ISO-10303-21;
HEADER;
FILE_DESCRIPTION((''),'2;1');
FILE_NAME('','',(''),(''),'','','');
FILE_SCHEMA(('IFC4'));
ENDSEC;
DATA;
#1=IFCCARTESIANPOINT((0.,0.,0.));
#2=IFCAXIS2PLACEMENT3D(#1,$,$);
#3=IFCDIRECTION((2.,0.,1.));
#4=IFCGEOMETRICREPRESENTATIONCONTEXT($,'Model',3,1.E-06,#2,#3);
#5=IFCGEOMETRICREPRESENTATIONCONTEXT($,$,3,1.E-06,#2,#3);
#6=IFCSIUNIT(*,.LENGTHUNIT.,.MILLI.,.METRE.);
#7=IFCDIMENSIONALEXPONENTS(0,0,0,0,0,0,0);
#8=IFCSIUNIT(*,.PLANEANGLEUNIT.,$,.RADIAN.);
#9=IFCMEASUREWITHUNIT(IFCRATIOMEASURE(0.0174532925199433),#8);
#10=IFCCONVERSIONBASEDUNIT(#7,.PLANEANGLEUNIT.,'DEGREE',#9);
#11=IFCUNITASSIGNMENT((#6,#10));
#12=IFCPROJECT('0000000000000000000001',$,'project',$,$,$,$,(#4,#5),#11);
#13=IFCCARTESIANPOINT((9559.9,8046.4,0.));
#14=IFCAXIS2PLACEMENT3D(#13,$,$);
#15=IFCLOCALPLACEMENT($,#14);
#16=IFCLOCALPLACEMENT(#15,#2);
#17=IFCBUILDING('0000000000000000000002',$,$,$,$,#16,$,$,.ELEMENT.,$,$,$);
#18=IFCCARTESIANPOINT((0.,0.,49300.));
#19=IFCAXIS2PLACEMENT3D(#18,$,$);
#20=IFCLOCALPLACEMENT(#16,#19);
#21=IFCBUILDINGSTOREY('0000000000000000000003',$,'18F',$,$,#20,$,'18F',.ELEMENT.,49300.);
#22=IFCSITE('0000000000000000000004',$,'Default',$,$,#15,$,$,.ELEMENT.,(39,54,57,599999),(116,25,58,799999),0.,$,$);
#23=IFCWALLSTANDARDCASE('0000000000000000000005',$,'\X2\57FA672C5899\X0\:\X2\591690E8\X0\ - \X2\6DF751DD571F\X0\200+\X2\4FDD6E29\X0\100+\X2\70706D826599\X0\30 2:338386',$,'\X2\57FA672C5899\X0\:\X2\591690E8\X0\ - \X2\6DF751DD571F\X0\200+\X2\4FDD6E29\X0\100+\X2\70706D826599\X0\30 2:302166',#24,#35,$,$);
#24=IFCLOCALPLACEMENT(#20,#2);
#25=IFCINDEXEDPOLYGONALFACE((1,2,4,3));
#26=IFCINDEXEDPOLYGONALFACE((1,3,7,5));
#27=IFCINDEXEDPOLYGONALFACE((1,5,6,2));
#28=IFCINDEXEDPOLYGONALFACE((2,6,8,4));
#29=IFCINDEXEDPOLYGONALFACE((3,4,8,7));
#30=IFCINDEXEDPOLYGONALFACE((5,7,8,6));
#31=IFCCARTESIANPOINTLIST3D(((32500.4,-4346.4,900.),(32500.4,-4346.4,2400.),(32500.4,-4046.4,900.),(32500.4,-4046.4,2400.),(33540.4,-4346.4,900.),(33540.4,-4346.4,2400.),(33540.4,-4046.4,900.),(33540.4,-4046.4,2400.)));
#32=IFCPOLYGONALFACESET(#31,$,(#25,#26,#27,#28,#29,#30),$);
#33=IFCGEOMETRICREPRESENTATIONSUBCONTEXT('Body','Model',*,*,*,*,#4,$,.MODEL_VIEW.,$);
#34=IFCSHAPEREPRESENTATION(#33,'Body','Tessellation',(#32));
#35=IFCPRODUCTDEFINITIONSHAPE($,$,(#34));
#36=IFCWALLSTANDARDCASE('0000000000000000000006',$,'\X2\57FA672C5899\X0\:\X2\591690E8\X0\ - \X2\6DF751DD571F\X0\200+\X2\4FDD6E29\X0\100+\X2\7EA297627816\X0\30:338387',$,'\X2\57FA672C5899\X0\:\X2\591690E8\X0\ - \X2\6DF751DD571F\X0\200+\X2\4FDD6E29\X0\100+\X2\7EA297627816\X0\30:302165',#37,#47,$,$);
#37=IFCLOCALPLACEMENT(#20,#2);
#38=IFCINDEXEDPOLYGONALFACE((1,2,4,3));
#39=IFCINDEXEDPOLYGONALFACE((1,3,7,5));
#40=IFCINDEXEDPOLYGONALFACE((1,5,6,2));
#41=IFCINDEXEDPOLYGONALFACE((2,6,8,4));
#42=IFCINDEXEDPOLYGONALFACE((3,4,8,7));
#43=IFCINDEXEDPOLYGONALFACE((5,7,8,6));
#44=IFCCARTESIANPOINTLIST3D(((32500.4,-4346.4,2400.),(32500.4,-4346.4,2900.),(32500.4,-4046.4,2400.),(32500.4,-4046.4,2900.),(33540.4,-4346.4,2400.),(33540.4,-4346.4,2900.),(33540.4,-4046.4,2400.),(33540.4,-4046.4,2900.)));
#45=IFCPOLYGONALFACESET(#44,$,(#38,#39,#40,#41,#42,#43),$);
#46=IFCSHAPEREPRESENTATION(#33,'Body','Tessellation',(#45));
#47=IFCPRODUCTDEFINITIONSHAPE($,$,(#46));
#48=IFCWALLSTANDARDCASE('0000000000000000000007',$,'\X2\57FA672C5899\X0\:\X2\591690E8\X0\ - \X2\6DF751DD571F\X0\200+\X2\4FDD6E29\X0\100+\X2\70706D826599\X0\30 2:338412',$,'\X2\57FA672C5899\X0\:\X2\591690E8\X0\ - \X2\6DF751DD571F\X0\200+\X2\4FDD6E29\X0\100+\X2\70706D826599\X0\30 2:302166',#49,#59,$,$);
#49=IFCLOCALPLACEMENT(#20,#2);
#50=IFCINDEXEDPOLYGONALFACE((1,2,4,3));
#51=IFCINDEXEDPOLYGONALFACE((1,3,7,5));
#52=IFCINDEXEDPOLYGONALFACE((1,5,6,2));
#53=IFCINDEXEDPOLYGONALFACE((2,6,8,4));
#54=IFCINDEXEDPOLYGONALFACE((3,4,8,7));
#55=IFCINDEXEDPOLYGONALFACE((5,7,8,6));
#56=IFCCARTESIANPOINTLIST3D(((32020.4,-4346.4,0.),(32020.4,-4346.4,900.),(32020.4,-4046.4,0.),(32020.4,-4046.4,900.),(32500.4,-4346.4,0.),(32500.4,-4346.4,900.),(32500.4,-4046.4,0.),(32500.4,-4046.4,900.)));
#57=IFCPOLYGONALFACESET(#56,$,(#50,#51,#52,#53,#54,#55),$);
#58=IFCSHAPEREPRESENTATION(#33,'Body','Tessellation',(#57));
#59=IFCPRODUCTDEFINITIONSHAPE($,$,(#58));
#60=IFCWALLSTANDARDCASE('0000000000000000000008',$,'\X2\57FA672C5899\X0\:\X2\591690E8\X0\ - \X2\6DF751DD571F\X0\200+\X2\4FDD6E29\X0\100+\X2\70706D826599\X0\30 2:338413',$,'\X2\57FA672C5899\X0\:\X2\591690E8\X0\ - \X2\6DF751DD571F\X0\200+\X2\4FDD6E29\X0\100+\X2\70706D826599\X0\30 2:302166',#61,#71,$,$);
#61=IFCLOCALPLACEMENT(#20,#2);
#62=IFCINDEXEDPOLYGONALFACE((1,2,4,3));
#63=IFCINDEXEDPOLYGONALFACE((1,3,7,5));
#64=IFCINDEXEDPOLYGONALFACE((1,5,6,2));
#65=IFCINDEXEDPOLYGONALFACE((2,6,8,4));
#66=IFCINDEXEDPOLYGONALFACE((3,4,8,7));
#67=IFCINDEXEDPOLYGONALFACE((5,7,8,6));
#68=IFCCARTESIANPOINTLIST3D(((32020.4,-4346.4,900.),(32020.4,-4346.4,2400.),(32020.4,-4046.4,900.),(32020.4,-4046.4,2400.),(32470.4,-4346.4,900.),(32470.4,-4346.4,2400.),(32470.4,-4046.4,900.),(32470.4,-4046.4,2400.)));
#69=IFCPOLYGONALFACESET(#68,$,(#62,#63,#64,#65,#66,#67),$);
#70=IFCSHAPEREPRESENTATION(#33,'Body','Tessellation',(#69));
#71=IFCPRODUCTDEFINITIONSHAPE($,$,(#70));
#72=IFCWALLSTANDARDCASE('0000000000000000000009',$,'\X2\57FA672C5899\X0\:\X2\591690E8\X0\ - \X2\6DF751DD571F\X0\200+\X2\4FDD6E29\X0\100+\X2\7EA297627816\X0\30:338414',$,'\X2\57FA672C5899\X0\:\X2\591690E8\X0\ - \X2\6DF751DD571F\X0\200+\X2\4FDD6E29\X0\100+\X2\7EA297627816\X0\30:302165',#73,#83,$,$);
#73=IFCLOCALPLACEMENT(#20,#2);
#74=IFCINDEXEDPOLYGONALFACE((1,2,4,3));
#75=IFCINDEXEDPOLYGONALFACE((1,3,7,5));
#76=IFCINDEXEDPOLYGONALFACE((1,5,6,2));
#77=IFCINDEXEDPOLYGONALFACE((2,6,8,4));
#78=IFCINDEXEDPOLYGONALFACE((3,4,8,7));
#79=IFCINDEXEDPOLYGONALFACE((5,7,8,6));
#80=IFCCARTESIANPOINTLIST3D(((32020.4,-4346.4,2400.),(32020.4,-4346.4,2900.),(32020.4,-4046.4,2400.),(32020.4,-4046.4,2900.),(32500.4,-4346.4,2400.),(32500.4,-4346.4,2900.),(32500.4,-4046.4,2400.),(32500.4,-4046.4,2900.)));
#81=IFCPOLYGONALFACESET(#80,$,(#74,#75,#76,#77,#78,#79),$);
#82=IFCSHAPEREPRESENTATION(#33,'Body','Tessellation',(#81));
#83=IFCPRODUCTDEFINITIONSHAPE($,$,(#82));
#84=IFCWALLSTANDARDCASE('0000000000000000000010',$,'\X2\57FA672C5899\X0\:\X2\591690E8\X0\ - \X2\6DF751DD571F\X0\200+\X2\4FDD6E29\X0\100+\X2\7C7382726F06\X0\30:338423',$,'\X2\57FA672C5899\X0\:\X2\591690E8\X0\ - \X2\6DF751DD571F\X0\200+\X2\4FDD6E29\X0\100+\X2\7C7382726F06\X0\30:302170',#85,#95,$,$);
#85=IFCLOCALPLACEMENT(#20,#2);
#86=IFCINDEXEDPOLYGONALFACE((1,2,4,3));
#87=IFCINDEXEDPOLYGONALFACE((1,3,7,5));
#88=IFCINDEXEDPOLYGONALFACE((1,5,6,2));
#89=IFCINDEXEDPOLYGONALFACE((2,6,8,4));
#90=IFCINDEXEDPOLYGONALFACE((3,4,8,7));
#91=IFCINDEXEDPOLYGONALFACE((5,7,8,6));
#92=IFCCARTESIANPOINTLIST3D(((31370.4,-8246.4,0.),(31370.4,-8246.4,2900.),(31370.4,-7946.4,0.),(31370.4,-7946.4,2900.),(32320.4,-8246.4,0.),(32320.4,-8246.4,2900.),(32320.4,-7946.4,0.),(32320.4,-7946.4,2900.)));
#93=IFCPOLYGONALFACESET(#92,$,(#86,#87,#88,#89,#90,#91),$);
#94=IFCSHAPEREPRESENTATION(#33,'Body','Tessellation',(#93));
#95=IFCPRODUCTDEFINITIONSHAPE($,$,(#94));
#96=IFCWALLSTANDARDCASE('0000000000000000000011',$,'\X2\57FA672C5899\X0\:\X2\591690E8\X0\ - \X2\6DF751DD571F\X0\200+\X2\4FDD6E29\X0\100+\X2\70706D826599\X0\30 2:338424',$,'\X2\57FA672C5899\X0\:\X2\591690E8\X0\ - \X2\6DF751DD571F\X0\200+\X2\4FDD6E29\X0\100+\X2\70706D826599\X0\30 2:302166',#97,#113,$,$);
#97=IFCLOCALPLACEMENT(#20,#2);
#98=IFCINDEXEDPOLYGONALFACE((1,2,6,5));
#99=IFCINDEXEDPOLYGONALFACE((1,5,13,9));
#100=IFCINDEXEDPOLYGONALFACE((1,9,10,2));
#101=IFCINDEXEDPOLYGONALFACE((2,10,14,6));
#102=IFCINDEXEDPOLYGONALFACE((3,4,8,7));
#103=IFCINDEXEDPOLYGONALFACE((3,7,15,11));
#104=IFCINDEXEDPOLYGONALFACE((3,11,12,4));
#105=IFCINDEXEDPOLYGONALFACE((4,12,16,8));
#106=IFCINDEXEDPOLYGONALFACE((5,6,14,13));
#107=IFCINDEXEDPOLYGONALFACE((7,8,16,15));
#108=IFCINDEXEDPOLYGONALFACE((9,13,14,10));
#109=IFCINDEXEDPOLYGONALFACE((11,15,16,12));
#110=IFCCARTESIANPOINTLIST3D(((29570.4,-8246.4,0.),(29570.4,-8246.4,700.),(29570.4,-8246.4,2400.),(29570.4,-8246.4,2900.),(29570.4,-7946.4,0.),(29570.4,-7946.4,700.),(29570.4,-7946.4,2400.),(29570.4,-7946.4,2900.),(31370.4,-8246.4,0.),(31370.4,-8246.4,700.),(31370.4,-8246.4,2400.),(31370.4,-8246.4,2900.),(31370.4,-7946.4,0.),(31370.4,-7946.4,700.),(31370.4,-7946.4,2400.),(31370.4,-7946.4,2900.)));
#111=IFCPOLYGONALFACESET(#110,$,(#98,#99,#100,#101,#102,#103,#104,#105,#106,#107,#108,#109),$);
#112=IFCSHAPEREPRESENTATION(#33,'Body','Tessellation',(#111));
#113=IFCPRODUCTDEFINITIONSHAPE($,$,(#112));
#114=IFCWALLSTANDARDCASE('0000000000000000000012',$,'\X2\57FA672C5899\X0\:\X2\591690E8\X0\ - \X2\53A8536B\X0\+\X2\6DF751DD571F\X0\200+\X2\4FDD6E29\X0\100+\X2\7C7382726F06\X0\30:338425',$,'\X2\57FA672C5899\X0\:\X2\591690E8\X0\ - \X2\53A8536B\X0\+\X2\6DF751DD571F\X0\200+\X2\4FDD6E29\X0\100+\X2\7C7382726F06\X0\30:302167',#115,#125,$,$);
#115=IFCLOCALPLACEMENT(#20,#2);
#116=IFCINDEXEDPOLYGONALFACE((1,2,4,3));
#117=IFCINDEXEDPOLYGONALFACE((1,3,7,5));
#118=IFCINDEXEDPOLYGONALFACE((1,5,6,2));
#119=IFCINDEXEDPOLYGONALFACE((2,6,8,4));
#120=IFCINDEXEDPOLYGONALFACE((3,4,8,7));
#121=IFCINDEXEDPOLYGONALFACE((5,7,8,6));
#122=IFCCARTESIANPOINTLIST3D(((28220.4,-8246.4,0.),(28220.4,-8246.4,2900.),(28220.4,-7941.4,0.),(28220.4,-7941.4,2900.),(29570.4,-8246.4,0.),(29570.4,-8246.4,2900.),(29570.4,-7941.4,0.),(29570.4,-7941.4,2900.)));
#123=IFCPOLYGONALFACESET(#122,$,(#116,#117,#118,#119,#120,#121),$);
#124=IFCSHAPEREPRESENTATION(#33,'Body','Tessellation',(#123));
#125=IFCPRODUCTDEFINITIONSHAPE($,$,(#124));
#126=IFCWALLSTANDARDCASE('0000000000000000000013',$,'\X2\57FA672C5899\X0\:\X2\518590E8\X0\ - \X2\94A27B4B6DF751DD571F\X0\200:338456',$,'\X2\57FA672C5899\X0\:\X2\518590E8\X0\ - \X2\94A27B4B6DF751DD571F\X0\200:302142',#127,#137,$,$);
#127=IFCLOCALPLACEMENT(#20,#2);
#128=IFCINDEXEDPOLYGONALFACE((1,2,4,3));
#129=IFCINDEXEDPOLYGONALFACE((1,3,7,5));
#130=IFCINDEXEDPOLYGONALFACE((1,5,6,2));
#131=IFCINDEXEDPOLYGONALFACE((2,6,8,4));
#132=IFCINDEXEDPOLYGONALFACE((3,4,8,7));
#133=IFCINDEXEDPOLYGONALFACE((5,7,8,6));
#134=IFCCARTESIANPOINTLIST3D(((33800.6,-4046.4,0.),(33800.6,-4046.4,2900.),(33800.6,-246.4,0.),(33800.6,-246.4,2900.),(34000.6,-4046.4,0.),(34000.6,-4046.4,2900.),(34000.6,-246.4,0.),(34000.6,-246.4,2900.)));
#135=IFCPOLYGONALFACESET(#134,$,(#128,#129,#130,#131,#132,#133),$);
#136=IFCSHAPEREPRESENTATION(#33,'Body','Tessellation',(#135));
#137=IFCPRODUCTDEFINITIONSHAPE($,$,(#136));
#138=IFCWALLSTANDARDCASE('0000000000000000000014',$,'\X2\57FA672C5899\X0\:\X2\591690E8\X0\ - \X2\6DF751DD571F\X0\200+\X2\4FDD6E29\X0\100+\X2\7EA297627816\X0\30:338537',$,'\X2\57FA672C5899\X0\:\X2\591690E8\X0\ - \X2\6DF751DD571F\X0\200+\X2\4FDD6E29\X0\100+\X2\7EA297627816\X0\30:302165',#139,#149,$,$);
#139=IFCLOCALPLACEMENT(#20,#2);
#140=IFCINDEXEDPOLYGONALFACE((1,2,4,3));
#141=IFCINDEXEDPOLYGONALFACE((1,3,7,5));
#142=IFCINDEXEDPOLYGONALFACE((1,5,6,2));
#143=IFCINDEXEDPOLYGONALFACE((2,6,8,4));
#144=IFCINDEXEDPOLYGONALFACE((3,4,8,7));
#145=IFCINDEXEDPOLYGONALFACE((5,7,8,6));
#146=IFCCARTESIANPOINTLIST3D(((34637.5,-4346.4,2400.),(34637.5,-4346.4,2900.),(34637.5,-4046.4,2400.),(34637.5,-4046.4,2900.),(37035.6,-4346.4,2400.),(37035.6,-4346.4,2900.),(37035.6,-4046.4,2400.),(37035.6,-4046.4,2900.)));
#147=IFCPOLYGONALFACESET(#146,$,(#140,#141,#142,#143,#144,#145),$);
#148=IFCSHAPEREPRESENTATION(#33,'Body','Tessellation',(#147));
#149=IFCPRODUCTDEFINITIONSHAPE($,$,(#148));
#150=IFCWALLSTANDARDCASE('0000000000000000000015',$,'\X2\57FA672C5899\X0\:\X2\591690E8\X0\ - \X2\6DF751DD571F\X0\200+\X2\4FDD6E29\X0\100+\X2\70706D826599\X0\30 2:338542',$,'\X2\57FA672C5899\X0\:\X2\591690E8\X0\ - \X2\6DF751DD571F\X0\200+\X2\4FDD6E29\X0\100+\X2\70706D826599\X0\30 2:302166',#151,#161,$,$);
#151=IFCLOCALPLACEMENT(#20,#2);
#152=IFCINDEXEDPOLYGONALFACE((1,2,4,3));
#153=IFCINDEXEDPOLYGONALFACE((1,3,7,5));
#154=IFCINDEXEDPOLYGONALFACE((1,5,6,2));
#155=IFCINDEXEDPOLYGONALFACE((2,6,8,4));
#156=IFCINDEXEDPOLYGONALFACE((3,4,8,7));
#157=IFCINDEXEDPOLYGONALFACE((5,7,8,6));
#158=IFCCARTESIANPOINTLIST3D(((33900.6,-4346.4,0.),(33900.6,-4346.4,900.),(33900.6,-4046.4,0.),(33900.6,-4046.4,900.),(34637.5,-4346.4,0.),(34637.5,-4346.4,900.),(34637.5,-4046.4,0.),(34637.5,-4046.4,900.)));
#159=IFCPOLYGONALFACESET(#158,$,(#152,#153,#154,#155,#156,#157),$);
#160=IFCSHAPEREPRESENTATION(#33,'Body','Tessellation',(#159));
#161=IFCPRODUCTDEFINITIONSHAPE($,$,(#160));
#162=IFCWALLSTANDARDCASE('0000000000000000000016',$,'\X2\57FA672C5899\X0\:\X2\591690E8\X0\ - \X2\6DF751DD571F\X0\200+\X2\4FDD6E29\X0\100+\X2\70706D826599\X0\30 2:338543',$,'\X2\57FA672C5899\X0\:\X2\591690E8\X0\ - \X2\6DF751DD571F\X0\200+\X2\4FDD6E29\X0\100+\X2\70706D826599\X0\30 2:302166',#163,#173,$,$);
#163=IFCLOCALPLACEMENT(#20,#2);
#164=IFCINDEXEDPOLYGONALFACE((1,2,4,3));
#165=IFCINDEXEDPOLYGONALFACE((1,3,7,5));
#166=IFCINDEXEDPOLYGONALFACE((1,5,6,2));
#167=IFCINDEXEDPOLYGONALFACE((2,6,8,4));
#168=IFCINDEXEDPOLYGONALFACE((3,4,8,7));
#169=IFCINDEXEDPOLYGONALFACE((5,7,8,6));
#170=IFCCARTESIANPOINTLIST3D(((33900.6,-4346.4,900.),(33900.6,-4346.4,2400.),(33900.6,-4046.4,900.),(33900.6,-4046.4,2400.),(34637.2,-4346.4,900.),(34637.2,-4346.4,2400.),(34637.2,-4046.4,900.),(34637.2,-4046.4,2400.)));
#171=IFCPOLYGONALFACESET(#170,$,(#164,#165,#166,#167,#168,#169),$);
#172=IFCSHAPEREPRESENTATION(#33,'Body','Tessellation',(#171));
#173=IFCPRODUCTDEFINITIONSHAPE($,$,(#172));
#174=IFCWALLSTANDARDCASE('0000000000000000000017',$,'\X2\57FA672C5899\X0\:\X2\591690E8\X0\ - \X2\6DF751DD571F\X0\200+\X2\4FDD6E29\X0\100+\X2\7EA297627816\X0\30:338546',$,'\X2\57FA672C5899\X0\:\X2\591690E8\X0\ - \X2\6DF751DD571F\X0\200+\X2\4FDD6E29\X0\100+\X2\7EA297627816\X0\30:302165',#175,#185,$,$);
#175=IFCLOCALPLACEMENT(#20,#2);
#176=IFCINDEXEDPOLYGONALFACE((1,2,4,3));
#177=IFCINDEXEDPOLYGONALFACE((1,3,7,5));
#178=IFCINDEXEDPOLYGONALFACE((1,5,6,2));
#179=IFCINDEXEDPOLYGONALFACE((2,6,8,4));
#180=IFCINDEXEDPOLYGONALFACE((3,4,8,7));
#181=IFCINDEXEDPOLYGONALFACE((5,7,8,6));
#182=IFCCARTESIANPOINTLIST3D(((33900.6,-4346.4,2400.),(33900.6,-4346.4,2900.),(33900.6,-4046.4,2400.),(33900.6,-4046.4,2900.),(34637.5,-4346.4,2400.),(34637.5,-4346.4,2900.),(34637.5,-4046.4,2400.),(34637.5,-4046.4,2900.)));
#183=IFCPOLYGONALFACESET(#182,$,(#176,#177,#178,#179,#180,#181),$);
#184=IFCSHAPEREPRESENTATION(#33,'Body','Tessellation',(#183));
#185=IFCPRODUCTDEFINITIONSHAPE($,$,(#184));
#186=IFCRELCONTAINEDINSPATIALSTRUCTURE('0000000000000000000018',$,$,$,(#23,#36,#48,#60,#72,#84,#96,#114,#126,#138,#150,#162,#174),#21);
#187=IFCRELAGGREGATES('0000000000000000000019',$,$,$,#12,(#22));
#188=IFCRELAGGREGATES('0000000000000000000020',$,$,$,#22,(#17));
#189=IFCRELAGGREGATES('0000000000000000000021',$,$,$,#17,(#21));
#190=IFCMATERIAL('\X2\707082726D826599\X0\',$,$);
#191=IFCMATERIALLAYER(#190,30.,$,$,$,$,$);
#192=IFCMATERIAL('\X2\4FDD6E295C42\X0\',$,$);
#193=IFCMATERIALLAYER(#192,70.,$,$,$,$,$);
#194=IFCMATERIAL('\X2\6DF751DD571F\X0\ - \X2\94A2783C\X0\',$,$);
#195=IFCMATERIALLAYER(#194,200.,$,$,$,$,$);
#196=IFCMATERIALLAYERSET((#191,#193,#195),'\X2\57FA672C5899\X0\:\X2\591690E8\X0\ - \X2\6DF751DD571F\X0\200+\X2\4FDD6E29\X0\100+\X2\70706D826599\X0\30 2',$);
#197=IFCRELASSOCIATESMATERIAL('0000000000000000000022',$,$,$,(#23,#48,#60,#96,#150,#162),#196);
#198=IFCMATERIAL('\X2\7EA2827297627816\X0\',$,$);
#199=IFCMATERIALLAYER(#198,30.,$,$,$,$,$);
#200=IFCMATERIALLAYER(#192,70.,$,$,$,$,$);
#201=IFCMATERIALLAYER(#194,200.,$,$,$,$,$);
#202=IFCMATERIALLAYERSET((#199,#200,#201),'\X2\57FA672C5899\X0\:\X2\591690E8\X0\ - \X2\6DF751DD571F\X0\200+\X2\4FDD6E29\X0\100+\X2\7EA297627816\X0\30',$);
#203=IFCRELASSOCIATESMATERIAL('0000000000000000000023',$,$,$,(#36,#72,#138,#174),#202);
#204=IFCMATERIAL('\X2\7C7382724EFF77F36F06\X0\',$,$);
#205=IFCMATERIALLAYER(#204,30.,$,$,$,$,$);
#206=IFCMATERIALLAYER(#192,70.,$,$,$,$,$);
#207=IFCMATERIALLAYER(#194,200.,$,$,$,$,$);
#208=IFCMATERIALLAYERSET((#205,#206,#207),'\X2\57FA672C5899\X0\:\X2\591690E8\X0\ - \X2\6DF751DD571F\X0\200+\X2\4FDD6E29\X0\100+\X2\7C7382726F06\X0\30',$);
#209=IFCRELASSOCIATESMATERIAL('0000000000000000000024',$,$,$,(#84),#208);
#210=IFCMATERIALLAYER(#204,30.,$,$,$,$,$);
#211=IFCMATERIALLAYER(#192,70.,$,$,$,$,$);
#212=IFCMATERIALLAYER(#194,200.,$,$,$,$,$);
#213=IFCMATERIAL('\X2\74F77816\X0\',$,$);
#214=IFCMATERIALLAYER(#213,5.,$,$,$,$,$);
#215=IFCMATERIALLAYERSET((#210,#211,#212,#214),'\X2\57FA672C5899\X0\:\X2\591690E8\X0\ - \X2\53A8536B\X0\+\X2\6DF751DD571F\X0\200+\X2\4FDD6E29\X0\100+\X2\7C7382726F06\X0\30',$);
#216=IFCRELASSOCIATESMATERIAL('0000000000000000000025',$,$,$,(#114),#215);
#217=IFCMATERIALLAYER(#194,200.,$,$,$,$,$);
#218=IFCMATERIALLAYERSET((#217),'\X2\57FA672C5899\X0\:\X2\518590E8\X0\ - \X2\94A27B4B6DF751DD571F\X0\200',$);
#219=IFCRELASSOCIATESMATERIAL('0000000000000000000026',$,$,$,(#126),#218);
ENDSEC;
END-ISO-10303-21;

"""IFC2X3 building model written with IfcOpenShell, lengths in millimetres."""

from ifc_helpers import new_model, entity, si_unit, converted_unit, direction, frame, frame_2d, origin, place, context, subcontext, project, spatial, rectangle, extrude, material, layer, layer_set, layer_usage, element, save


model = new_model("IFC2X3")

# Units and contexts
model_context = context("Model", 3, precision=1e-06, world=origin(), true_north=direction((2.0, 0.0, 1.0)))
context_of_model = context(None, 3, precision=1e-06, world=origin(), true_north=direction((2.0, 0.0, 1.0)))
body_context = subcontext(model_context, "Body", "Model", "MODEL_VIEW")
ifc_project = project(units=[si_unit("LENGTHUNIT", "METRE", prefix="MILLI"), converted_unit("PLANEANGLEUNIT", "DEGREE", entity("IfcRatioMeasure", 0.0174532925199433), si_unit("PLANEANGLEUNIT", "RADIAN"), dimensions=[0, 0, 0, 0, 0, 0, 0])], contexts=[model_context, context_of_model])

# Site, building, storey
site_placement = place(None, frame((9559.9, 8046.4, 0.0)))
site = spatial("IfcSite", under=ifc_project, at=site_placement, Name="Default", CompositionType="ELEMENT", RefLatitude=(39, 54, 57, 599999), RefLongitude=(116, 25, 58, 799999), RefElevation=0.0)
building_placement = place(site_placement, origin())
building = spatial("IfcBuilding", under=site, at=building_placement, CompositionType="ELEMENT")
storey_placement = place(building_placement, frame((0.0, 0.0, 49300.0)))
storey = spatial("IfcBuildingStorey", under=building, at=storey_placement, Name="18F", LongName="18F", CompositionType="ELEMENT", Elevation=49300.0)

# Shared definitions
ifc_material_1 = material(Name="米色仿石漆")
ifc_layer_1 = layer(ifc_material_1, 30.0)
ifc_material_2 = material(Name="保温层")
ifc_layer_2 = layer(ifc_material_2, 70.0)
ifc_material_3 = material(Name="混凝土 - 钢砼")
ifc_layer_3 = layer(ifc_material_3, 200.0)
ifc_layer_set_1 = layer_set([ifc_layer_1, ifc_layer_2, ifc_layer_3], Name="基本墙:外部 - 混凝土200+保温100+米色漆30")
ifc_layer_4 = layer(ifc_material_3, 200.0)
ifc_layer_set_2 = layer_set([ifc_layer_4], Name="基本墙:内部 - 钢筋混凝土200")

# Shared definitions
ifc_material_4 = material(Name="灰色涂料")
ifc_layer_5 = layer(ifc_material_4, 30.0)
ifc_layer_6 = layer(ifc_material_2, 70.0)
ifc_layer_7 = layer(ifc_material_3, 200.0)
ifc_layer_set_3 = layer_set([ifc_layer_5, ifc_layer_6, ifc_layer_7], Name="基本墙:外部 - 混凝土200+保温100+灰涂料30 2")

# Shared definitions
ifc_material_5 = material(Name="红色面砖")
ifc_layer_8 = layer(ifc_material_5, 30.0)
ifc_layer_9 = layer(ifc_material_2, 70.0)
ifc_layer_10 = layer(ifc_material_3, 200.0)
ifc_layer_set_4 = layer_set([ifc_layer_8, ifc_layer_9, ifc_layer_10], Name="基本墙:外部 - 混凝土200+保温100+红面砖30")

# Walls
ifc_layer_usage_1 = layer_usage(ifc_layer_set_3, "AXIS2", "POSITIVE", -150.0)
wall_1_placement = place(storey_placement, frame((32500.4, -4196.4, 900.0)))
element("IfcWallStandardCase", 1, at=wall_1_placement, inside=storey, material=ifc_layer_usage_1, Name="基本墙:外部 - 混凝土200+保温100+灰涂料30 2:338386", ObjectType="基本墙:外部 - 混凝土200+保温100+灰涂料30 2:302166", context=body_context, shape_type="SweptSolid", body=[
    extrude(rectangle(XDim=1040.0, YDim=300.0, at=frame_2d((520.0, 0.0), x_axis=(-1.0, 0.0))), origin(), (0.0, 0.0, 1.0), 1500.0),
])
ifc_layer_usage_2 = layer_usage(ifc_layer_set_4, "AXIS2", "POSITIVE", -150.0)
wall_2_placement = place(storey_placement, frame((32500.4, -4196.4, 2400.0)))
element("IfcWallStandardCase", 2, at=wall_2_placement, inside=storey, material=ifc_layer_usage_2, Name="基本墙:外部 - 混凝土200+保温100+红面砖30:338387", ObjectType="基本墙:外部 - 混凝土200+保温100+红面砖30:302165", context=body_context, shape_type="SweptSolid", body=[
    extrude(rectangle(XDim=1040.0, YDim=300.0, at=frame_2d((520.0, 0.0), x_axis=(-1.0, 0.0))), origin(), (0.0, 0.0, 1.0), 500.0),
])
ifc_layer_usage_3 = layer_usage(ifc_layer_set_3, "AXIS2", "POSITIVE", -150.0)
wall_3_placement = place(storey_placement, frame((32020.4, -4196.4, 0.0)))
element("IfcWallStandardCase", 3, at=wall_3_placement, inside=storey, material=ifc_layer_usage_3, Name="基本墙:外部 - 混凝土200+保温100+灰涂料30 2:338412", ObjectType="基本墙:外部 - 混凝土200+保温100+灰涂料30 2:302166", context=body_context, shape_type="SweptSolid", body=[
    extrude(rectangle(XDim=480.0, YDim=300.0, at=frame_2d((240.0, 0.0), x_axis=(-1.0, 0.0))), origin(), (0.0, 0.0, 1.0), 900.0),
])
ifc_layer_usage_4 = layer_usage(ifc_layer_set_3, "AXIS2", "POSITIVE", -150.0)
wall_4_placement = place(storey_placement, frame((32020.4, -4196.4, 900.0)))
element("IfcWallStandardCase", 4, at=wall_4_placement, inside=storey, material=ifc_layer_usage_4, Name="基本墙:外部 - 混凝土200+保温100+灰涂料30 2:338413", ObjectType="基本墙:外部 - 混凝土200+保温100+灰涂料30 2:302166", context=body_context, shape_type="SweptSolid", body=[
    extrude(rectangle(XDim=450.0, YDim=300.0, at=frame_2d((225.0, 0.0), x_axis=(-1.0, 0.0))), origin(), (0.0, 0.0, 1.0), 1500.0),
])
ifc_layer_usage_5 = layer_usage(ifc_layer_set_4, "AXIS2", "POSITIVE", -150.0)
wall_5_placement = place(storey_placement, frame((32020.4, -4196.4, 2400.0)))
element("IfcWallStandardCase", 5, at=wall_5_placement, inside=storey, material=ifc_layer_usage_5, Name="基本墙:外部 - 混凝土200+保温100+红面砖30:338414", ObjectType="基本墙:外部 - 混凝土200+保温100+红面砖30:302165", context=body_context, shape_type="SweptSolid", body=[
    extrude(rectangle(XDim=480.0, YDim=300.0, at=frame_2d((240.0, 0.0), x_axis=(-1.0, 0.0))), origin(), (0.0, 0.0, 1.0), 500.0),
])
ifc_layer_usage_6 = layer_usage(ifc_layer_set_1, "AXIS2", "POSITIVE", -150.0)
wall_6_placement = place(storey_placement, frame((31370.4, -8096.4, 0.0)))
element("IfcWallStandardCase", 6, at=wall_6_placement, inside=storey, material=ifc_layer_usage_6, Name="基本墙:外部 - 混凝土200+保温100+米色漆30:338423", ObjectType="基本墙:外部 - 混凝土200+保温100+米色漆30:302170", context=body_context, shape_type="SweptSolid", body=[
    extrude(rectangle(XDim=950.0, YDim=300.0, at=frame_2d((475.0, 0.0), x_axis=(-1.0, 0.0))), origin(), (0.0, 0.0, 1.0), 2900.0),
])

# Wall, opening
ifc_layer_usage_7 = layer_usage(ifc_layer_set_3, "AXIS2", "POSITIVE", -150.0)
wall_7_placement = place(storey_placement, frame((29570.4, -8096.4, 0.0)))
wall_7 = element("IfcWallStandardCase", 7, at=wall_7_placement, inside=storey, material=ifc_layer_usage_7, Name="基本墙:外部 - 混凝土200+保温100+灰涂料30 2:338424", ObjectType="基本墙:外部 - 混凝土200+保温100+灰涂料30 2:302166", context=body_context, shape_type="SweptSolid", body=[
    extrude(rectangle(XDim=1800.0, YDim=300.0, at=frame_2d((900.0, 0.0), x_axis=(-1.0, 0.0))), origin(), (0.0, 0.0, 1.0), 2900.0),
])
opening_1_placement = place(wall_7_placement, frame((0.0, -150.0, 700.0)))
element("IfcOpeningElement", 8, at=opening_1_placement, cuts=wall_7, ObjectType="Opening", context=body_context, shape_type="SweptSolid", body=[
    extrude(rectangle(XDim=1700.0, YDim=1800.0, at=frame_2d((850.0, 900.0), x_axis=(1.0, 0.0))), frame((0.0, 0.0, 0.0), z_axis=(0.0, 1.0, 0.0), x_axis=(0.0, 0.0, 1.0)), (0.0, 0.0, 1.0), 300.0),
])

# Walls
ifc_layer_11 = layer(ifc_material_1, 30.0)
ifc_layer_12 = layer(ifc_material_2, 70.0)
ifc_layer_13 = layer(ifc_material_3, 200.0)
ifc_material_6 = material(Name="瓷砖")
ifc_layer_14 = layer(ifc_material_6, 5.0)
ifc_layer_set_5 = layer_set([ifc_layer_11, ifc_layer_12, ifc_layer_13, ifc_layer_14], Name="基本墙:外部 - 厨卫+混凝土200+保温100+米色漆30")
ifc_layer_usage_8 = layer_usage(ifc_layer_set_5, "AXIS2", "POSITIVE", -152.5)
wall_8_placement = place(storey_placement, frame((28220.4, -8093.9, 0.0)))
element("IfcWallStandardCase", 9, at=wall_8_placement, inside=storey, material=ifc_layer_usage_8, Name="基本墙:外部 - 厨卫+混凝土200+保温100+米色漆30:338425", ObjectType="基本墙:外部 - 厨卫+混凝土200+保温100+米色漆30:302167", context=body_context, shape_type="SweptSolid", body=[
    extrude(rectangle(XDim=1350.0, YDim=305.0, at=frame_2d((675.0, 0.0), x_axis=(-1.0, 0.0))), origin(), (0.0, 0.0, 1.0), 2900.0),
])
ifc_layer_usage_9 = layer_usage(ifc_layer_set_2, "AXIS2", "POSITIVE", -100.0)
wall_9_placement = place(storey_placement, frame((33900.6, -4046.4, 0.0), z_axis=(0.0, 0.0, 1.0), x_axis=(0.0, 1.0, 0.0)))
element("IfcWallStandardCase", 10, at=wall_9_placement, inside=storey, material=ifc_layer_usage_9, Name="基本墙:内部 - 钢筋混凝土200:338456", ObjectType="基本墙:内部 - 钢筋混凝土200:302142", context=body_context, shape_type="SweptSolid", body=[
    extrude(rectangle(XDim=3800.0, YDim=200.0, at=frame_2d((1900.0, 0.0), x_axis=(-1.0, 0.0))), origin(), (0.0, 0.0, 1.0), 2900.0),
])
ifc_layer_usage_10 = layer_usage(ifc_layer_set_4, "AXIS2", "NEGATIVE", 150.0)
wall_10_placement = place(storey_placement, frame((37035.6, -4196.4, 2400.0), z_axis=(0.0, 0.0, 1.0), x_axis=(-1.0, 0.0, 0.0)))
element("IfcWallStandardCase", 11, at=wall_10_placement, inside=storey, material=ifc_layer_usage_10, Name="基本墙:外部 - 混凝土200+保温100+红面砖30:338537", ObjectType="基本墙:外部 - 混凝土200+保温100+红面砖30:302165", context=body_context, shape_type="SweptSolid", body=[
    extrude(rectangle(XDim=2398.1, YDim=300.0, at=frame_2d((1199.0, 0.0), x_axis=(-1.0, 0.0))), origin(), (0.0, 0.0, 1.0), 500.0),
])

# Walls
ifc_layer_usage_11 = layer_usage(ifc_layer_set_3, "AXIS2", "NEGATIVE", 150.0)
wall_11_placement = place(storey_placement, frame((34637.5, -4196.4, 0.0), z_axis=(0.0, 0.0, 1.0), x_axis=(-1.0, 0.0, 0.0)))
element("IfcWallStandardCase", 12, at=wall_11_placement, inside=storey, material=ifc_layer_usage_11, Name="基本墙:外部 - 混凝土200+保温100+灰涂料30 2:338542", ObjectType="基本墙:外部 - 混凝土200+保温100+灰涂料30 2:302166", context=body_context, shape_type="SweptSolid", body=[
    extrude(rectangle(XDim=736.9, YDim=300.0, at=frame_2d((368.5, 0.0), x_axis=(-1.0, 0.0))), origin(), (0.0, 0.0, 1.0), 900.0),
])
ifc_layer_usage_12 = layer_usage(ifc_layer_set_3, "AXIS2", "NEGATIVE", 150.0)
wall_12_placement = place(storey_placement, frame((34637.2, -4196.4, 900.0), z_axis=(0.0, 0.0, 1.0), x_axis=(-1.0, 0.0, 0.0)))
element("IfcWallStandardCase", 13, at=wall_12_placement, inside=storey, material=ifc_layer_usage_12, Name="基本墙:外部 - 混凝土200+保温100+灰涂料30 2:338543", ObjectType="基本墙:外部 - 混凝土200+保温100+灰涂料30 2:302166", context=body_context, shape_type="SweptSolid", body=[
    extrude(rectangle(XDim=736.6, YDim=300.0, at=frame_2d((368.3, 0.0), x_axis=(-1.0, 0.0))), origin(), (0.0, 0.0, 1.0), 1500.0),
])
ifc_layer_usage_13 = layer_usage(ifc_layer_set_4, "AXIS2", "NEGATIVE", 150.0)
wall_13_placement = place(storey_placement, frame((34637.5, -4196.4, 2400.0), z_axis=(0.0, 0.0, 1.0), x_axis=(-1.0, 0.0, 0.0)))
element("IfcWallStandardCase", 14, at=wall_13_placement, inside=storey, material=ifc_layer_usage_13, Name="基本墙:外部 - 混凝土200+保温100+红面砖30:338546", ObjectType="基本墙:外部 - 混凝土200+保温100+红面砖30:302165", context=body_context, shape_type="SweptSolid", body=[
    extrude(rectangle(XDim=736.9, YDim=300.0, at=frame_2d((368.5, 0.0), x_axis=(-1.0, 0.0))), origin(), (0.0, 0.0, 1.0), 500.0),
])

save(model, "model.ifc")
